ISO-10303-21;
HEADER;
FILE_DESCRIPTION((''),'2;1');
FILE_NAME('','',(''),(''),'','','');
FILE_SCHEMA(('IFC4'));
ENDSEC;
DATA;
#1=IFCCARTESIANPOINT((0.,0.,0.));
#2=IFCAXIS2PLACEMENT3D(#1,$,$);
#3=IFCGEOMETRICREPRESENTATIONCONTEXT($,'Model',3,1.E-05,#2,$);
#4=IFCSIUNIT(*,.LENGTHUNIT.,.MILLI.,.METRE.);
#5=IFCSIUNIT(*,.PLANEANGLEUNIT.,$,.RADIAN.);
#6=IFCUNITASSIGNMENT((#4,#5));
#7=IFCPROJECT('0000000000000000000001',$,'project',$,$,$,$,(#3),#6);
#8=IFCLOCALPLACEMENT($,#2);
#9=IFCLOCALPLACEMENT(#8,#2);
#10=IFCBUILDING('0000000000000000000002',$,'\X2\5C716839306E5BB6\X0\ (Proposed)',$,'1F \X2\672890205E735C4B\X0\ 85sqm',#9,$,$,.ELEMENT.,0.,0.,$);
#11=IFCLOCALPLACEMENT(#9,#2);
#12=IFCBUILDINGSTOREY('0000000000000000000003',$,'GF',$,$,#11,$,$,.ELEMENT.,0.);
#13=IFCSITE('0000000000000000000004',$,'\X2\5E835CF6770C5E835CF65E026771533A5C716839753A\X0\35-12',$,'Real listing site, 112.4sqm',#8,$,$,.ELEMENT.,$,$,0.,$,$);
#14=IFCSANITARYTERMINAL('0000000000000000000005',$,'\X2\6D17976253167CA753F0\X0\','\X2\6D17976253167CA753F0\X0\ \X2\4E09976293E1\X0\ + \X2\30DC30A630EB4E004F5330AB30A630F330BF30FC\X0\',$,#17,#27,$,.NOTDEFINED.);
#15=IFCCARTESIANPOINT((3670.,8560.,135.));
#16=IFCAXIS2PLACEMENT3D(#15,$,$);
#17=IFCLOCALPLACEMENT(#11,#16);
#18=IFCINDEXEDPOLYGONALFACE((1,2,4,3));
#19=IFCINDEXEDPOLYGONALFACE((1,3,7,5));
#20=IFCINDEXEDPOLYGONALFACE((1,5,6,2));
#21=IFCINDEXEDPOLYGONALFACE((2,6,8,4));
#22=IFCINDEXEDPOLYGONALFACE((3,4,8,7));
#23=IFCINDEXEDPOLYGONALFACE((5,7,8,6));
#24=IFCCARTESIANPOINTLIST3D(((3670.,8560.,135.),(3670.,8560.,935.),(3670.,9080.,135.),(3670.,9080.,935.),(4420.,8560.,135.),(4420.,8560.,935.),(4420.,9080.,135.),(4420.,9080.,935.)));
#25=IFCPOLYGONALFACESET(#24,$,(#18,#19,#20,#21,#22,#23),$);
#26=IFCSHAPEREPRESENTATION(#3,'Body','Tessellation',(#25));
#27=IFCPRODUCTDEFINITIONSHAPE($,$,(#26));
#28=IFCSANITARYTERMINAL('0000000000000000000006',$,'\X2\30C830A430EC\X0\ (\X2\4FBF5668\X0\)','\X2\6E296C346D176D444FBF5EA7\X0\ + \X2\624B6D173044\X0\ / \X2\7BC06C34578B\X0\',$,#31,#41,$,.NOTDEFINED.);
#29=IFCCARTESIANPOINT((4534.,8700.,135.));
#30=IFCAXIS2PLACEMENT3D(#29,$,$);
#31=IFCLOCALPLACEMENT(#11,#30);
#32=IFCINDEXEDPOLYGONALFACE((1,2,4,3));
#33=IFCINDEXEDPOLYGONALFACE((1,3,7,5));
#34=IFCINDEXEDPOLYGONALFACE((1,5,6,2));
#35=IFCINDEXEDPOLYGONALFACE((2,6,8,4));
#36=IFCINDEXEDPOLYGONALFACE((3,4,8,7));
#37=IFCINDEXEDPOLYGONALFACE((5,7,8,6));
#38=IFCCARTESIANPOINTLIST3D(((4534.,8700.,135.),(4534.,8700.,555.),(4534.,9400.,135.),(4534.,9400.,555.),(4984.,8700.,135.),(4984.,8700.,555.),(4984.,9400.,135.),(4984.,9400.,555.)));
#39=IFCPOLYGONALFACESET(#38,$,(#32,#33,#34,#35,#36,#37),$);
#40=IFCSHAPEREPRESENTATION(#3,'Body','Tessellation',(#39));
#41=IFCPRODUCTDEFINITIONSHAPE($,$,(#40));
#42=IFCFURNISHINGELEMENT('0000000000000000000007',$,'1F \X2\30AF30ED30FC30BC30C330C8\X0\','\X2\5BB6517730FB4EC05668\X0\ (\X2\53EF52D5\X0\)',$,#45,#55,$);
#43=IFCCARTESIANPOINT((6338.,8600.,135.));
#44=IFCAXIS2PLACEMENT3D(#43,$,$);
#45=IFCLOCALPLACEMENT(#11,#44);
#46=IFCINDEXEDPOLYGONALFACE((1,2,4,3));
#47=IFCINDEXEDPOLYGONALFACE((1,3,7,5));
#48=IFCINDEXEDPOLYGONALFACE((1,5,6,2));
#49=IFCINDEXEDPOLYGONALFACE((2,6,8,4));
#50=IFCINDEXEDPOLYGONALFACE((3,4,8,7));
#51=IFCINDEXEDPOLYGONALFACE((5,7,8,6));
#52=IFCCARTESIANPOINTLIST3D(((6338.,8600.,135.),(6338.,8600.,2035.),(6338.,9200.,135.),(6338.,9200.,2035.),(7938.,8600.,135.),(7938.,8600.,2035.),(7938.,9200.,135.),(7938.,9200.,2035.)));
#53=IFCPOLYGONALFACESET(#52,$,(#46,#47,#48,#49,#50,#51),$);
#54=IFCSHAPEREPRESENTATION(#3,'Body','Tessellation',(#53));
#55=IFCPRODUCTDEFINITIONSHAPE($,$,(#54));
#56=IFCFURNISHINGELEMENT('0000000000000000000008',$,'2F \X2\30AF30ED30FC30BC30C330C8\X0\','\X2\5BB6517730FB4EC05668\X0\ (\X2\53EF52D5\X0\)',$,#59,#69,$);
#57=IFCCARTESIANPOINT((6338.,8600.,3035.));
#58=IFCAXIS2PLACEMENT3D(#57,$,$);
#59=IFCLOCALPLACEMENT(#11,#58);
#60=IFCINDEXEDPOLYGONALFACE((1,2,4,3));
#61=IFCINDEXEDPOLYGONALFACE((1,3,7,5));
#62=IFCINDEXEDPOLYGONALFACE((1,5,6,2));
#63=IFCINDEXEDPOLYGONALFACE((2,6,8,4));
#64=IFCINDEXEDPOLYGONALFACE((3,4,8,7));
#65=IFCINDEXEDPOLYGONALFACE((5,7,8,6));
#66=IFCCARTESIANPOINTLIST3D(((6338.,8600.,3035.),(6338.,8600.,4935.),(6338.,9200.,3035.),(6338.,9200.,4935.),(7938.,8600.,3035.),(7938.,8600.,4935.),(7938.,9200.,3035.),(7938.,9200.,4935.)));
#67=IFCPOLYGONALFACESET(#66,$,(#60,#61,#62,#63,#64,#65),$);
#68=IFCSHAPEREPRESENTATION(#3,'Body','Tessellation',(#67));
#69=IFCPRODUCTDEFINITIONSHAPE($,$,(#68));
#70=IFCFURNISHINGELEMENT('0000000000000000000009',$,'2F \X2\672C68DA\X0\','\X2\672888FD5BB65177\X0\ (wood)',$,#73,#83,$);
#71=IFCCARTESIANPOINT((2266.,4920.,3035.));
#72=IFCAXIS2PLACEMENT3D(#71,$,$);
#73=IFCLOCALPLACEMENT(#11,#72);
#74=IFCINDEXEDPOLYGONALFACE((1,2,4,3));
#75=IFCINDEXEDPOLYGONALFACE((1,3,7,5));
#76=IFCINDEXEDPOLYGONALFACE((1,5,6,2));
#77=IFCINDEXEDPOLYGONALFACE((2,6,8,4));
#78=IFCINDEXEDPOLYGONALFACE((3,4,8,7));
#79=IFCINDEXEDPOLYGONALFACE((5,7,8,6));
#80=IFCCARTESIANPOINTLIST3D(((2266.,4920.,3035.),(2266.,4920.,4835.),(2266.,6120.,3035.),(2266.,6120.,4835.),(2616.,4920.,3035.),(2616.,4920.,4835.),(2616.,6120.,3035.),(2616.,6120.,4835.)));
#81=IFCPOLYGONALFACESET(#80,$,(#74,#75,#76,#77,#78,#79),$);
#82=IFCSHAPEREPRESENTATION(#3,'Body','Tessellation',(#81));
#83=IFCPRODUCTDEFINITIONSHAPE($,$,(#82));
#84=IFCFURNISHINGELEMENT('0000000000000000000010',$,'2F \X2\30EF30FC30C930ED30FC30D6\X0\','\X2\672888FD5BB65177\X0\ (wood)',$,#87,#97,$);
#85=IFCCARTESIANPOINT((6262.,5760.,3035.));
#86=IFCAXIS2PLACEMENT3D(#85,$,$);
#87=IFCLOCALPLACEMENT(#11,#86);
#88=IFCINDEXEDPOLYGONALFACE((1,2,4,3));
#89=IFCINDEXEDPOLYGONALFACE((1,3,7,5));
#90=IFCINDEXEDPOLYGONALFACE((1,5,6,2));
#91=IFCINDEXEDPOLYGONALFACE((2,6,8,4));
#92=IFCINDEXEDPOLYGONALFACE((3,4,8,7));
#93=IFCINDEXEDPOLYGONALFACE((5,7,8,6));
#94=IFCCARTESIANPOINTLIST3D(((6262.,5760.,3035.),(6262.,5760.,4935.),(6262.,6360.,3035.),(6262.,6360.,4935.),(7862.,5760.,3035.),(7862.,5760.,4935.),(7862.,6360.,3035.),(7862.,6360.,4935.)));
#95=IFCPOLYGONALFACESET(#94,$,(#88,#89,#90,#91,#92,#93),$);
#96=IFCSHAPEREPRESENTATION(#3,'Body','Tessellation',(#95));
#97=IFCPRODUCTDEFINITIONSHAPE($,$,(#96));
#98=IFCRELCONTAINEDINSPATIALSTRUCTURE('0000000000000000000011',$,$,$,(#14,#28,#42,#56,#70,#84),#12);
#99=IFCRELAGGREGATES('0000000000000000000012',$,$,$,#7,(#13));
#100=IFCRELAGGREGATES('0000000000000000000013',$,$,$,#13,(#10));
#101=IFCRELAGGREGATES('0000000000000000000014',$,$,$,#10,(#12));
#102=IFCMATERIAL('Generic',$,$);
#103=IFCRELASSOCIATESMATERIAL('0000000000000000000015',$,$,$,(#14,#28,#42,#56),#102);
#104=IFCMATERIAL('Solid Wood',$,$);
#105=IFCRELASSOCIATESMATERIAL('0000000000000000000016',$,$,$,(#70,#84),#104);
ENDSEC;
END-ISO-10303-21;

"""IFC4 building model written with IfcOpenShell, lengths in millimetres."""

from ifc_helpers import new_model, si_unit, frame, frame_2d, origin, place, context, project, spatial, rectangle, extrude, material, element, save


model = new_model("IFC4")

# Units and contexts
model_context = context("Model", 3, precision=1e-05, world=origin())
ifc_project = project(units=[si_unit("LENGTHUNIT", "METRE", prefix="MILLI"), si_unit("PLANEANGLEUNIT", "RADIAN")], contexts=[model_context])

# Site, building, storey
site_placement = place(None, origin())
site = spatial("IfcSite", under=ifc_project, at=site_placement, Name="広島県広島市東区山根町35-12", ObjectType="Real listing site, 112.4sqm", CompositionType="ELEMENT", RefElevation=0.0)
building_placement = place(site_placement, origin())
building = spatial("IfcBuilding", under=site, at=building_placement, Name="山根の家 (Proposed)", ObjectType="1F 木造平屋 85sqm", CompositionType="ELEMENT", ElevationOfRefHeight=0.0, ElevationOfTerrain=0.0)
storey_placement = place(building_placement, origin())
storey = spatial("IfcBuildingStorey", under=building, at=storey_placement, Name="GF", CompositionType="ELEMENT", Elevation=0.0)

# Shared definitions
ifc_material_1 = material(Name="Solid Wood")

# Shared definitions
ifc_material_2 = material(Name="Generic")

# Sanitary terminals
sanitary_terminal_1_placement = place(storey_placement, frame((3670.0, 8560.0, 135.0)))
element("IfcSanitaryTerminal", 1, at=sanitary_terminal_1_placement, inside=storey, material=ifc_material_2, Name="洗面化粧台", Description="洗面化粧台 三面鏡 + ボウル一体カウンター", PredefinedType="NOTDEFINED", context=model_context, shape_type="SweptSolid", body=[
    extrude(rectangle(XDim=750.0, YDim=520.0, at=frame_2d((375.0, 260.0))), frame((3670.0, 8560.0, 135.0)), (0.0, 0.0, 1.0), 800.0),
])
sanitary_terminal_2_placement = place(storey_placement, frame((4534.0, 8700.0, 135.0)))
element("IfcSanitaryTerminal", 2, at=sanitary_terminal_2_placement, inside=storey, material=ifc_material_2, Name="トイレ (便器)", Description="温水洗浄便座 + 手洗い / 節水型", PredefinedType="NOTDEFINED", context=model_context, shape_type="SweptSolid", body=[
    extrude(rectangle(XDim=450.0, YDim=700.0, at=frame_2d((225.0, 350.0))), frame((4534.0, 8700.0, 135.0)), (0.0, 0.0, 1.0), 420.0),
])

# Furnishing elements
furnishing_1_placement = place(storey_placement, frame((6338.0, 8600.0, 135.0)))
element("IfcFurnishingElement", 3, at=furnishing_1_placement, inside=storey, material=ifc_material_2, Name="1F クローゼット", Description="家具・什器 (可動)", context=model_context, shape_type="SweptSolid", body=[
    extrude(rectangle(XDim=1600.0, YDim=600.0, at=frame_2d((800.0, 300.0))), frame((6338.0, 8600.0, 135.0)), (0.0, 0.0, 1.0), 1900.0),
])
furnishing_2_placement = place(storey_placement, frame((6338.0, 8600.0, 3035.0)))
element("IfcFurnishingElement", 4, at=furnishing_2_placement, inside=storey, material=ifc_material_2, Name="2F クローゼット", Description="家具・什器 (可動)", context=model_context, shape_type="SweptSolid", body=[
    extrude(rectangle(XDim=1600.0, YDim=600.0, at=frame_2d((800.0, 300.0))), frame((6338.0, 8600.0, 3035.0)), (0.0, 0.0, 1.0), 1900.0),
])
furnishing_3_placement = place(storey_placement, frame((2266.0, 4920.0, 3035.0)))
element("IfcFurnishingElement", 5, at=furnishing_3_placement, inside=storey, material=ifc_material_1, Name="2F 本棚", Description="木製家具 (wood)", context=model_context, shape_type="SweptSolid", body=[
    extrude(rectangle(XDim=350.0, YDim=1200.0, at=frame_2d((175.0, 600.0))), frame((2266.0, 4920.0, 3035.0)), (0.0, 0.0, 1.0), 1800.0),
])
furnishing_4_placement = place(storey_placement, frame((6262.0, 5760.0, 3035.0)))
element("IfcFurnishingElement", 6, at=furnishing_4_placement, inside=storey, material=ifc_material_1, Name="2F ワードローブ", Description="木製家具 (wood)", context=model_context, shape_type="SweptSolid", body=[
    extrude(rectangle(XDim=1600.0, YDim=600.0, at=frame_2d((800.0, 300.0))), frame((6262.0, 5760.0, 3035.0)), (0.0, 0.0, 1.0), 1900.0),
])

save(model, "model.ifc")
